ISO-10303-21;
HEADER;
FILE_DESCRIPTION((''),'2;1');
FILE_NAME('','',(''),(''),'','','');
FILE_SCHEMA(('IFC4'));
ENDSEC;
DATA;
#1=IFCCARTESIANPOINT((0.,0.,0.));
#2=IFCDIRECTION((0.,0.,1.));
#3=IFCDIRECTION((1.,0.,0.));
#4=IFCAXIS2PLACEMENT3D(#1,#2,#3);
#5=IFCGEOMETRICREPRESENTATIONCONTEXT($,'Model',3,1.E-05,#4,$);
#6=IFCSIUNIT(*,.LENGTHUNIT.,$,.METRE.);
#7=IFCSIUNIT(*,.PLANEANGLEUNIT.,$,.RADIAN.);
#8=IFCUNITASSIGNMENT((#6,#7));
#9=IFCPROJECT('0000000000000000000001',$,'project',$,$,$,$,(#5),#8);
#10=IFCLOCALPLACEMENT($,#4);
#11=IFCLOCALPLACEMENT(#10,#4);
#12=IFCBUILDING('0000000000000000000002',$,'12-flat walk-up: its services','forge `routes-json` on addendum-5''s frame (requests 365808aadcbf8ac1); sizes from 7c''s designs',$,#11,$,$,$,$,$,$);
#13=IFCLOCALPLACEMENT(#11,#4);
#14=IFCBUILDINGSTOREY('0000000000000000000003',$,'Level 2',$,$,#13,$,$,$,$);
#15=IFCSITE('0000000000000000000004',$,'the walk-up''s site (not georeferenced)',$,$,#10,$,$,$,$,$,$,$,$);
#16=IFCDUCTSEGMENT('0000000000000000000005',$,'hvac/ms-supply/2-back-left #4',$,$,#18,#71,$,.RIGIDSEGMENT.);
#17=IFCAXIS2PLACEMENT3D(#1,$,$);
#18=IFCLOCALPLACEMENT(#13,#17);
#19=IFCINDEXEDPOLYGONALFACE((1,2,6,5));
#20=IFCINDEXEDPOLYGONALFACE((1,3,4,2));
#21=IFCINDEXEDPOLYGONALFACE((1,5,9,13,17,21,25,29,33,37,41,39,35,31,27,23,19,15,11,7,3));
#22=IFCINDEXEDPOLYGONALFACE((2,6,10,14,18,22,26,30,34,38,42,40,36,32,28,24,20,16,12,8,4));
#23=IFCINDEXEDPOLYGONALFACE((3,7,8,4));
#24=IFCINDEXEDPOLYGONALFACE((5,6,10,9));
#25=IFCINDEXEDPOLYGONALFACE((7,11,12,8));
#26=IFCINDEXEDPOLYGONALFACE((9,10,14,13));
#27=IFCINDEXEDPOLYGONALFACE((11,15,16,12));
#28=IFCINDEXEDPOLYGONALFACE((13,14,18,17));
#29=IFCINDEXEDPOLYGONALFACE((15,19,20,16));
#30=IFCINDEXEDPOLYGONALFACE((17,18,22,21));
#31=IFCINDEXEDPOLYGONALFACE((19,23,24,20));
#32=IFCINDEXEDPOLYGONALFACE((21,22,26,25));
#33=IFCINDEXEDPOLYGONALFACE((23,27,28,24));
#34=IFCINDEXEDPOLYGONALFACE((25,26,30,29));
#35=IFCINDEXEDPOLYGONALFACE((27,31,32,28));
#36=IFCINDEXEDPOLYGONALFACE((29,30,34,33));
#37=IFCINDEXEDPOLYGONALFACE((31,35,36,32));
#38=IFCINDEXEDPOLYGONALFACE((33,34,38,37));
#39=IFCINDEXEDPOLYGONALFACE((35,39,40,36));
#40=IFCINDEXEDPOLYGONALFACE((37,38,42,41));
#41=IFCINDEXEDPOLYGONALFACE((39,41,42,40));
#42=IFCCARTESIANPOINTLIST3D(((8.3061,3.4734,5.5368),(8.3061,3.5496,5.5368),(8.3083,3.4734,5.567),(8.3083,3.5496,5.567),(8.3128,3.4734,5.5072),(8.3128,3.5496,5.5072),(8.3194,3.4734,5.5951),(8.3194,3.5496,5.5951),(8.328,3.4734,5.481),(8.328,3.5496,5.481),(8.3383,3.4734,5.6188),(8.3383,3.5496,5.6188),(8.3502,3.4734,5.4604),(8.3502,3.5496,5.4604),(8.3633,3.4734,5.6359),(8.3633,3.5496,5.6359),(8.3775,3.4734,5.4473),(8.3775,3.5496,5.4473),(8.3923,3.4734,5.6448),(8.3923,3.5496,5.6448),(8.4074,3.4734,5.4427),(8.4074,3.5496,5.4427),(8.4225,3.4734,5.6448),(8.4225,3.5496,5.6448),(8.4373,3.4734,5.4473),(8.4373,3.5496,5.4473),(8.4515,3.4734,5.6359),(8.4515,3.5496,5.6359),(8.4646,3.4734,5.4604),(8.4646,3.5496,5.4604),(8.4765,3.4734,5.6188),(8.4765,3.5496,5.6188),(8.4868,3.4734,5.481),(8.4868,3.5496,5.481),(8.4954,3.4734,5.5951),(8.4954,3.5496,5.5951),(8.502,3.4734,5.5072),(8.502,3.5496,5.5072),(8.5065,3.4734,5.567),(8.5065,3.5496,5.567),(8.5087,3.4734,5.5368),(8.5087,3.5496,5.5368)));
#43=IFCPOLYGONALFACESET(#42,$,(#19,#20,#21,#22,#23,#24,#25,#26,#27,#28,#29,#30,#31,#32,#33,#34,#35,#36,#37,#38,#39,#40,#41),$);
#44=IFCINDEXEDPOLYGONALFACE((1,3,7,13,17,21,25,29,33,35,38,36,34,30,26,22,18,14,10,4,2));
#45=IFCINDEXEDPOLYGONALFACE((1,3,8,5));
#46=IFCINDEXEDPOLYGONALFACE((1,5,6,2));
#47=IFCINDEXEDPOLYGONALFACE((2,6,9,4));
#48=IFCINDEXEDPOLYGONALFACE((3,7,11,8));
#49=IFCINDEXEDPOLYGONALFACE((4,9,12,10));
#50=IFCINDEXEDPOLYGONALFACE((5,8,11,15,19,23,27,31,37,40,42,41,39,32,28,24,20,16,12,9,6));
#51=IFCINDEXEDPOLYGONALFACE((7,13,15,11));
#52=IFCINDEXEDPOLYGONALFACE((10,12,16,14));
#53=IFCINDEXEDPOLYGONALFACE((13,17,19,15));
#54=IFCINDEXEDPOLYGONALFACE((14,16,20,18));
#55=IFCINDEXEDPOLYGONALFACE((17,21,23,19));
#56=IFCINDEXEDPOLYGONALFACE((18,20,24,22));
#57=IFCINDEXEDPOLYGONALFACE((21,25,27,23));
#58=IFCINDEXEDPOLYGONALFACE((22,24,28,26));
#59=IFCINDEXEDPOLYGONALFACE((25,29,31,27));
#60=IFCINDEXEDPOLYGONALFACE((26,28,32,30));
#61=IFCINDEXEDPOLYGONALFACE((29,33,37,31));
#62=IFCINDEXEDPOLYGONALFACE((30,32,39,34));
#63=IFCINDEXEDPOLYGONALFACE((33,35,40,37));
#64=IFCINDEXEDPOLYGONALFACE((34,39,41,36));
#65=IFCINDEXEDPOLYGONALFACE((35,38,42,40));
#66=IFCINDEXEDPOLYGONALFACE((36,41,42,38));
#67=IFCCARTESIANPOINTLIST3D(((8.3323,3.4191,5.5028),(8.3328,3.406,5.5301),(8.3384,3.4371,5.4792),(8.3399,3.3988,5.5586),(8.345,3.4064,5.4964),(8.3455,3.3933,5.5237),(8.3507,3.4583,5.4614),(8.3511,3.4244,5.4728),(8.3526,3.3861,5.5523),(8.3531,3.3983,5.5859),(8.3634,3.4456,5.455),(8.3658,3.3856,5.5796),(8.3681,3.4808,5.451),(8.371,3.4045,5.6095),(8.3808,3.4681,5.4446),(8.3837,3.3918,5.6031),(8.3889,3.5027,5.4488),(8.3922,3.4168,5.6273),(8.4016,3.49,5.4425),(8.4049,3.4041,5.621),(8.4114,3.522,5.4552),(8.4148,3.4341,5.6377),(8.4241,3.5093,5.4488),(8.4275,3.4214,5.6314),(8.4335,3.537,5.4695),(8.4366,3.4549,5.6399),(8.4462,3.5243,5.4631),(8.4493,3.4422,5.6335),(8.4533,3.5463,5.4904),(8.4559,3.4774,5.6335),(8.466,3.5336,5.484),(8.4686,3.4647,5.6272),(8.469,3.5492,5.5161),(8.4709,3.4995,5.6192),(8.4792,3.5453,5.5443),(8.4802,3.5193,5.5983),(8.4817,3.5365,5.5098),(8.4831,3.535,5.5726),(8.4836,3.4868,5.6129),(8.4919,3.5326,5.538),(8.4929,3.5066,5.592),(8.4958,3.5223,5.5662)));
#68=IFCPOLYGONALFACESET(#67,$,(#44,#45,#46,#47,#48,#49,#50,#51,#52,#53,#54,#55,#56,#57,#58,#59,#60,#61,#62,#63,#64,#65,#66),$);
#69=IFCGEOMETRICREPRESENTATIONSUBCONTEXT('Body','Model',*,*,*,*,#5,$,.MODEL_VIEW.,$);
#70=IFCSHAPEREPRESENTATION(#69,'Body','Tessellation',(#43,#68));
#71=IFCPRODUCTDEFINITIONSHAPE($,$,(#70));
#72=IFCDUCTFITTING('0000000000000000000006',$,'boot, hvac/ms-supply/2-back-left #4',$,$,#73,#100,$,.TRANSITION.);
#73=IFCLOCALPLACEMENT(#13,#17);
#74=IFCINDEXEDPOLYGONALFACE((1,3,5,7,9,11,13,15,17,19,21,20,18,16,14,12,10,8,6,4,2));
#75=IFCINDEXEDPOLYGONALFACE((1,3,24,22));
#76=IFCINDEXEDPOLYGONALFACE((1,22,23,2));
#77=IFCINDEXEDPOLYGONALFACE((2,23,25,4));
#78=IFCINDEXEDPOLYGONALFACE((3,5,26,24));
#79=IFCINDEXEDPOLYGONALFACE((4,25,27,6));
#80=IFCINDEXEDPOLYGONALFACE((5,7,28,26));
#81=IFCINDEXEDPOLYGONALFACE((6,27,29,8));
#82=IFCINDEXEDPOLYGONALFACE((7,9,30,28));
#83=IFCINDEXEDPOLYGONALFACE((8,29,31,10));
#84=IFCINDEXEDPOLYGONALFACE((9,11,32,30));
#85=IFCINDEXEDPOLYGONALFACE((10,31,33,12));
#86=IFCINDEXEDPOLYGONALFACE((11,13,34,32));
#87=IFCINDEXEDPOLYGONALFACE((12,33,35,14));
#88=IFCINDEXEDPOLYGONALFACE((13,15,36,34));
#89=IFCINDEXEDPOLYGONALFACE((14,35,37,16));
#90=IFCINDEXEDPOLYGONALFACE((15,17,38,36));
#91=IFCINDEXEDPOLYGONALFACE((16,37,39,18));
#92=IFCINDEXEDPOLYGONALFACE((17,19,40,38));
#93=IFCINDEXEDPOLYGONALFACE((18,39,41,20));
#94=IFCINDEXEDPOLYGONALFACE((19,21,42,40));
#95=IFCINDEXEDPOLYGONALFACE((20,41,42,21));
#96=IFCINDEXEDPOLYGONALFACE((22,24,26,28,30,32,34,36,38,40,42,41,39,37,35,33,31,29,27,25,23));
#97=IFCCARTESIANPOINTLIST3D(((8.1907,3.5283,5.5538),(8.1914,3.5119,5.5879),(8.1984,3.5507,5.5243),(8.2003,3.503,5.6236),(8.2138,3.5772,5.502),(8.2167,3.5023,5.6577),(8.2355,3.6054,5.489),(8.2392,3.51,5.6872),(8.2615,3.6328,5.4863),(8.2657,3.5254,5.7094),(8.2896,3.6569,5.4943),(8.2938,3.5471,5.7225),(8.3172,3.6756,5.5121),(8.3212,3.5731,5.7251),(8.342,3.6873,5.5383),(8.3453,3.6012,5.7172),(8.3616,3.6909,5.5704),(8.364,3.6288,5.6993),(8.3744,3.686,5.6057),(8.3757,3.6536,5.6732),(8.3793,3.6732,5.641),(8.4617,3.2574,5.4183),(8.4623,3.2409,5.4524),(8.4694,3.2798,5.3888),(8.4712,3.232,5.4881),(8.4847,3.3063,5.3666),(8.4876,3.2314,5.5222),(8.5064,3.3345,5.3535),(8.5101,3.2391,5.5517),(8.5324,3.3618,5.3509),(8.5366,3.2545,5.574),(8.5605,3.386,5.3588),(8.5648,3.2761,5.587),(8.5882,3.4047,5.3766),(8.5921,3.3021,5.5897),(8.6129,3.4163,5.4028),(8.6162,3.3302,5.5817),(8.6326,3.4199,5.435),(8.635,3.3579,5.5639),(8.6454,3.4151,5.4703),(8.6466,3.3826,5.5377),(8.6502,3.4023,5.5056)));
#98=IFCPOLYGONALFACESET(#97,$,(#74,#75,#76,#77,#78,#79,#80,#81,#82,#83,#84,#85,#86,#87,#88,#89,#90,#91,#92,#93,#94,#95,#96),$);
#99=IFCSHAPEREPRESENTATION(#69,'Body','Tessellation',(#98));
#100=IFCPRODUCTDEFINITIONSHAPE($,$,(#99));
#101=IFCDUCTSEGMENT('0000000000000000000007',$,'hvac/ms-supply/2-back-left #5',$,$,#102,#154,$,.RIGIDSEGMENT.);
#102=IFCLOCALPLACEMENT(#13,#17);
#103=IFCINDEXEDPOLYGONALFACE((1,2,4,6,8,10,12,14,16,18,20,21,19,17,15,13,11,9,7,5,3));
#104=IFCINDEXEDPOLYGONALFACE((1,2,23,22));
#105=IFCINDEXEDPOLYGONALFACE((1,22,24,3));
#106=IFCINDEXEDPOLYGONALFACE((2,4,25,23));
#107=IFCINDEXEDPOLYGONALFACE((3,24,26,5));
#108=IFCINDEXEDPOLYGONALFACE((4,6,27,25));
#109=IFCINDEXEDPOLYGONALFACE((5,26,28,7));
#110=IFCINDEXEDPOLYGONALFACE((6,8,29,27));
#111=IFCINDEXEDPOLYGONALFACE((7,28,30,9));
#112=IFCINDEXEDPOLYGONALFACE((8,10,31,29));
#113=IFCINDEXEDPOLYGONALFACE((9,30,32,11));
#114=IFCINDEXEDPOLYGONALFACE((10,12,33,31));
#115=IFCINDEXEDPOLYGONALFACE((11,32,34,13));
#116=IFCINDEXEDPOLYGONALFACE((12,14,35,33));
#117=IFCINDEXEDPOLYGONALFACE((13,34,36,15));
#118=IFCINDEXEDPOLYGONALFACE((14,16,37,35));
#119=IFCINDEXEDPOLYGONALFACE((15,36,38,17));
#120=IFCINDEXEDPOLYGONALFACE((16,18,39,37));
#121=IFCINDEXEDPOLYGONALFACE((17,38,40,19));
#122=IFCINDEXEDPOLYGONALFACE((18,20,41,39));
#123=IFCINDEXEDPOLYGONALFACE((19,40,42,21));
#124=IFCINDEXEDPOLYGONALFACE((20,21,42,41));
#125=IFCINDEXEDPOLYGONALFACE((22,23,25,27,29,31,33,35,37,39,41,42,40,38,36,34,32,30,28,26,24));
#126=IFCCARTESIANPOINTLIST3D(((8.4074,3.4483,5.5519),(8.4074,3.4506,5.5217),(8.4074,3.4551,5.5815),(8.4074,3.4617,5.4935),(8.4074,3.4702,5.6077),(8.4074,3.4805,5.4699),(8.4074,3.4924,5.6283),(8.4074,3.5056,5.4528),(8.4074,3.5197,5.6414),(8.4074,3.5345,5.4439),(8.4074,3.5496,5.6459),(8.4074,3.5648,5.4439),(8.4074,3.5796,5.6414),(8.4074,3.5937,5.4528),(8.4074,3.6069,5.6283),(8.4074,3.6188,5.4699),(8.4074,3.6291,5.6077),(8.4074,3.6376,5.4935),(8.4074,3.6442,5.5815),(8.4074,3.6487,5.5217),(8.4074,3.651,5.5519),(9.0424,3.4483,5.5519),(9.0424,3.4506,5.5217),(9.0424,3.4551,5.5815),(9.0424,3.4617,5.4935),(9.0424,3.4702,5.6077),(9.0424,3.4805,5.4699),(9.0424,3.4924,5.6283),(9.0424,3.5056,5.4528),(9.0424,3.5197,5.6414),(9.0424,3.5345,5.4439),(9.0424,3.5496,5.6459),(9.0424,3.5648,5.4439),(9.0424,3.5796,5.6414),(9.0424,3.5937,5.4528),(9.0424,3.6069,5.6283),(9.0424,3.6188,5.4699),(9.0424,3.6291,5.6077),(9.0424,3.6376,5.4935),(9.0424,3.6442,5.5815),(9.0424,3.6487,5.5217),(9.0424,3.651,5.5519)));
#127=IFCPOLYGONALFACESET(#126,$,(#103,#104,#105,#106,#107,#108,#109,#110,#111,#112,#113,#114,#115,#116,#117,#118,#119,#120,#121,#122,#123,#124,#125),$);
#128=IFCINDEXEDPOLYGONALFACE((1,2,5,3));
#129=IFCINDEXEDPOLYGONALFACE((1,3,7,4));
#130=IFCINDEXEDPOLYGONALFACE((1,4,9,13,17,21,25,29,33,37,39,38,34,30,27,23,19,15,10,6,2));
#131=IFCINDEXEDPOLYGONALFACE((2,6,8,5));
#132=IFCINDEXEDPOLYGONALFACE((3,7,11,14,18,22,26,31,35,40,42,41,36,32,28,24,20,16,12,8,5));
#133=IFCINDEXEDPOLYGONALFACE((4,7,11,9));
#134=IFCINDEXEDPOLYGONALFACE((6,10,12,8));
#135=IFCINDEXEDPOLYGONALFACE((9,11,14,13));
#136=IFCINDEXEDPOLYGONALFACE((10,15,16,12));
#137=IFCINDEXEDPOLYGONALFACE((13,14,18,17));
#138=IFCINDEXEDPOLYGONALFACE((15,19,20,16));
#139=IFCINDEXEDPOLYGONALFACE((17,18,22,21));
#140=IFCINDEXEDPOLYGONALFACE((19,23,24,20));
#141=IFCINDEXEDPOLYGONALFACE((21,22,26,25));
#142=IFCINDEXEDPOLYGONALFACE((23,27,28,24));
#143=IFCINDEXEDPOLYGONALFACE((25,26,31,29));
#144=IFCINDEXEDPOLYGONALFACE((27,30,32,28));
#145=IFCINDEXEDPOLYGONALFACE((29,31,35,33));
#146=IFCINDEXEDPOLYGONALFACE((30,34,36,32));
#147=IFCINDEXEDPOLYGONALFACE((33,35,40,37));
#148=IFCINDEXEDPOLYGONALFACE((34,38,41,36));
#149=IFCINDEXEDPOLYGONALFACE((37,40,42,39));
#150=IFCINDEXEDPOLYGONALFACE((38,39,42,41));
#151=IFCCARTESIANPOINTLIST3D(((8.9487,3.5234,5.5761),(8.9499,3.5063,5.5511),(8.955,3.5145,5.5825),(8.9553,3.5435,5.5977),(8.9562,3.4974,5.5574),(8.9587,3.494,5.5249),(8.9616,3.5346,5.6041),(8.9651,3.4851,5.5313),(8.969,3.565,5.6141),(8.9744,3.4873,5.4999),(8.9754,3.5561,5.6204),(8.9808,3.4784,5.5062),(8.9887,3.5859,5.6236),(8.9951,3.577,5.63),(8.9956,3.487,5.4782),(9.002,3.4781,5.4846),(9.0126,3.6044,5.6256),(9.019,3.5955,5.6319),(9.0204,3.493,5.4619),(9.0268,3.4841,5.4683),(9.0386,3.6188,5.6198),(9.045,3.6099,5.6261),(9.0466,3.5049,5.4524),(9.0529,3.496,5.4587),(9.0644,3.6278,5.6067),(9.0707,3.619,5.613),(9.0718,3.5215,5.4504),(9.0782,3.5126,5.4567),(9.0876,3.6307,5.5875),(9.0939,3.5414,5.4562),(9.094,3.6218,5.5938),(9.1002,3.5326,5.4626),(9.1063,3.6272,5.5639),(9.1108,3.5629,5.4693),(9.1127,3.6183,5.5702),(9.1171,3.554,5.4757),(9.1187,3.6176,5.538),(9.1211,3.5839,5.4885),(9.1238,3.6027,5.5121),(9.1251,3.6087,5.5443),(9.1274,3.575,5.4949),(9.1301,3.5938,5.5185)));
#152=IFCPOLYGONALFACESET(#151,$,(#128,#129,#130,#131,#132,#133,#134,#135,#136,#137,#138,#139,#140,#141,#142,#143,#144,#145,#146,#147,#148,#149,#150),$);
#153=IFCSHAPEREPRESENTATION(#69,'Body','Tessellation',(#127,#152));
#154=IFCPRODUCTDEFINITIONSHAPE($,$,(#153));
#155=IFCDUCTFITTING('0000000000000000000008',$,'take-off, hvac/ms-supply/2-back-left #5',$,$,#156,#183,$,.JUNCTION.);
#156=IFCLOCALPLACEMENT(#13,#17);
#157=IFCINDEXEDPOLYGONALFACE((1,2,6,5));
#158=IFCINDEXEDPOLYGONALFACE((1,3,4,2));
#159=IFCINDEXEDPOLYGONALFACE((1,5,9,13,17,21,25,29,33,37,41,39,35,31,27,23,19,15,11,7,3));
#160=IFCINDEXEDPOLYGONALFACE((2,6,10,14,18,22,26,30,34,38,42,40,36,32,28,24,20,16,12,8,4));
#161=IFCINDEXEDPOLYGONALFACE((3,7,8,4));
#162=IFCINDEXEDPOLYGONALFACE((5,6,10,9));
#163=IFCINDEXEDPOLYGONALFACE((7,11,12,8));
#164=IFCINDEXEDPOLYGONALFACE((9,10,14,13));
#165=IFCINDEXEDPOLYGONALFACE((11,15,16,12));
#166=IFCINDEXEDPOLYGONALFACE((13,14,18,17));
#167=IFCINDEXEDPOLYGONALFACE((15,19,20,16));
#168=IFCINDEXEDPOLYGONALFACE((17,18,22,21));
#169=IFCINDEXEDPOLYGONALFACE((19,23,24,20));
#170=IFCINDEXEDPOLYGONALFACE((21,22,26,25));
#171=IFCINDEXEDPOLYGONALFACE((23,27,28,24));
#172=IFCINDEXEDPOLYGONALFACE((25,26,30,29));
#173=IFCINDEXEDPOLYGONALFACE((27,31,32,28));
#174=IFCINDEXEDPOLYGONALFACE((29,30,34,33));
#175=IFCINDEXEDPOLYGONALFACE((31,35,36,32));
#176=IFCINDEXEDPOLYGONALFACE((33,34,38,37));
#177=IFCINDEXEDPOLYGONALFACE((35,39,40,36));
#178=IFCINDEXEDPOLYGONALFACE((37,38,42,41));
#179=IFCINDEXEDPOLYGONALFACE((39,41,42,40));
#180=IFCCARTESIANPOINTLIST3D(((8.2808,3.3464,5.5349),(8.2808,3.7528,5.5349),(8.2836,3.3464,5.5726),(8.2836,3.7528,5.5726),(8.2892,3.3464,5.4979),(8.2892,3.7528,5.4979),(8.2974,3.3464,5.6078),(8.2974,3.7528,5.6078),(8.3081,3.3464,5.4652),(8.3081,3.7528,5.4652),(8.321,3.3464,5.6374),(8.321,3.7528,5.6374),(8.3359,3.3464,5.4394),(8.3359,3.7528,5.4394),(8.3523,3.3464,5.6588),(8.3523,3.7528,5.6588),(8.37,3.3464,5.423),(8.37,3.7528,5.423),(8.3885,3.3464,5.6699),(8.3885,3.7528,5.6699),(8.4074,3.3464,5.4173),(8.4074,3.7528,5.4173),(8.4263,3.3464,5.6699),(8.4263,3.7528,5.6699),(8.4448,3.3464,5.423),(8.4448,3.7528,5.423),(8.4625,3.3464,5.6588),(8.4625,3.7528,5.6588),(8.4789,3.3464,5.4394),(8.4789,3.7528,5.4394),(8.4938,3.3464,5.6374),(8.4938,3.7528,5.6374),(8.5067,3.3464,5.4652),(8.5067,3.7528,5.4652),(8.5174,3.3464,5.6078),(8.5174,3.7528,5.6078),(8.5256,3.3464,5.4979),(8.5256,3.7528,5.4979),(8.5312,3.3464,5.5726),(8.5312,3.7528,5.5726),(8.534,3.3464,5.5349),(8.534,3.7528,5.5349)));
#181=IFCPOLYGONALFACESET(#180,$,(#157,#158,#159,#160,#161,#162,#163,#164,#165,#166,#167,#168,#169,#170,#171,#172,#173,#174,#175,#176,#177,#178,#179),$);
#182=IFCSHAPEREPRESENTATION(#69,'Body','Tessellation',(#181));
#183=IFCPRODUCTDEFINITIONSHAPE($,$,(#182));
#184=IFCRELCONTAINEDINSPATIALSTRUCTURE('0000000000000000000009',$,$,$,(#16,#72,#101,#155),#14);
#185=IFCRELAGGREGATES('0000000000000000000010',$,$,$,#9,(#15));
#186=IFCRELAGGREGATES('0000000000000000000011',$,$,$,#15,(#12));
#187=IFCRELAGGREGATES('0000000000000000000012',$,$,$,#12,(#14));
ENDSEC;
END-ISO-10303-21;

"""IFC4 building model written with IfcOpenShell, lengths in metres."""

from ifc_helpers import new_model, entity, si_unit, frame, origin_with_axes, place, context, subcontext, project, spatial, element, save


model = new_model("IFC4")

# Units and contexts
model_context = context("Model", 3, precision=1e-05, world=origin_with_axes())
body_context = subcontext(model_context, "Body", "Model", "MODEL_VIEW")
ifc_project = project(units=[si_unit("LENGTHUNIT", "METRE"), si_unit("PLANEANGLEUNIT", "RADIAN")], contexts=[model_context])

# Site, building, storey
site_placement = place(None, origin_with_axes())
site = spatial("IfcSite", under=ifc_project, at=site_placement, Name="the walk-up's site (not georeferenced)")
building_placement = place(site_placement, origin_with_axes())
building = spatial("IfcBuilding", under=site, at=building_placement, Name="12-flat walk-up: its services", Description="forge `routes-json` on addendum-5's frame (requests 365808aadcbf8ac1); sizes from 7c's designs")
storey_placement = place(building_placement, origin_with_axes())
storey = spatial("IfcBuildingStorey", under=building, at=storey_placement, Name="Level 2")

# Duct segment
duct_segment_1_placement = place(storey_placement, frame((8.4074, 3.5496, 5.5443), z_axis=(0.0, 0.0, 1.0), x_axis=(1.0, 0.0, 0.0)))
element("IfcDuctSegment", 1, at=duct_segment_1_placement, inside=storey, Name="hvac/ms-supply/2-back-left #4", PredefinedType="RIGIDSEGMENT", context=body_context, shape_type="AdvancedSweptSolid", body=[
    entity("IfcSweptDiskSolid", entity("IfcPolyline", [entity("IfcCartesianPoint", [0.0, 0.0, 0.0]), entity("IfcCartesianPoint", [0.0, -0.0762, 0.0])]), 0.1016),
    entity("IfcSweptDiskSolid", entity("IfcPolyline", [entity("IfcCartesianPoint", [0.0, -0.0762, 0.0]), entity("IfcCartesianPoint", [0.0127, -0.0889, -0.0063])]), 0.1016),
])

# Duct fitting
duct_fitting_1_placement = place(storey_placement, frame((8.2846, 3.5962, 5.6057), z_axis=(0.0, 0.0, 1.0), x_axis=(1.0, 0.0, 0.0)))
element("IfcDuctFitting", 2, at=duct_fitting_1_placement, inside=storey, Name="boot, hvac/ms-supply/2-back-left #4", PredefinedType="TRANSITION", context=body_context, shape_type="AdvancedSweptSolid", body=[
    entity("IfcSweptDiskSolid", entity("IfcPolyline", [entity("IfcCartesianPoint", [0.0, 0.0, 0.0]), entity("IfcCartesianPoint", [0.2709, -0.2709, -0.1355])]), 0.127),
])

# Duct segment
duct_segment_2_placement = place(storey_placement, frame((8.4074, 3.5496, 5.5443), z_axis=(0.0, 0.0, 1.0), x_axis=(1.0, 0.0, 0.0)))
element("IfcDuctSegment", 3, at=duct_segment_2_placement, inside=storey, Name="hvac/ms-supply/2-back-left #5", PredefinedType="RIGIDSEGMENT", context=body_context, shape_type="AdvancedSweptSolid", body=[
    entity("IfcSweptDiskSolid", entity("IfcPolyline", [entity("IfcCartesianPoint", [0.0, 0.0, 0.0]), entity("IfcCartesianPoint", [0.635, 0.0, 0.0])]), 0.1016),
    entity("IfcSweptDiskSolid", entity("IfcPolyline", [entity("IfcCartesianPoint", [0.635, 0.0, 0.0]), entity("IfcCartesianPoint", [0.6287, 0.0089, -0.0063])]), 0.1016),
])

# Duct fitting
duct_fitting_2_placement = place(storey_placement, frame((8.4074, 3.7528, 5.5443), z_axis=(0.0, 0.0, 1.0), x_axis=(1.0, 0.0, 0.0)))
element("IfcDuctFitting", 4, at=duct_fitting_2_placement, inside=storey, Name="take-off, hvac/ms-supply/2-back-left #5", PredefinedType="JUNCTION", context=body_context, shape_type="AdvancedSweptSolid", body=[
    entity("IfcSweptDiskSolid", entity("IfcPolyline", [entity("IfcCartesianPoint", [0.0, 0.0, 0.0]), entity("IfcCartesianPoint", [0.0, -0.4064, 0.0])]), 0.127),
])

save(model, "model.ifc")
